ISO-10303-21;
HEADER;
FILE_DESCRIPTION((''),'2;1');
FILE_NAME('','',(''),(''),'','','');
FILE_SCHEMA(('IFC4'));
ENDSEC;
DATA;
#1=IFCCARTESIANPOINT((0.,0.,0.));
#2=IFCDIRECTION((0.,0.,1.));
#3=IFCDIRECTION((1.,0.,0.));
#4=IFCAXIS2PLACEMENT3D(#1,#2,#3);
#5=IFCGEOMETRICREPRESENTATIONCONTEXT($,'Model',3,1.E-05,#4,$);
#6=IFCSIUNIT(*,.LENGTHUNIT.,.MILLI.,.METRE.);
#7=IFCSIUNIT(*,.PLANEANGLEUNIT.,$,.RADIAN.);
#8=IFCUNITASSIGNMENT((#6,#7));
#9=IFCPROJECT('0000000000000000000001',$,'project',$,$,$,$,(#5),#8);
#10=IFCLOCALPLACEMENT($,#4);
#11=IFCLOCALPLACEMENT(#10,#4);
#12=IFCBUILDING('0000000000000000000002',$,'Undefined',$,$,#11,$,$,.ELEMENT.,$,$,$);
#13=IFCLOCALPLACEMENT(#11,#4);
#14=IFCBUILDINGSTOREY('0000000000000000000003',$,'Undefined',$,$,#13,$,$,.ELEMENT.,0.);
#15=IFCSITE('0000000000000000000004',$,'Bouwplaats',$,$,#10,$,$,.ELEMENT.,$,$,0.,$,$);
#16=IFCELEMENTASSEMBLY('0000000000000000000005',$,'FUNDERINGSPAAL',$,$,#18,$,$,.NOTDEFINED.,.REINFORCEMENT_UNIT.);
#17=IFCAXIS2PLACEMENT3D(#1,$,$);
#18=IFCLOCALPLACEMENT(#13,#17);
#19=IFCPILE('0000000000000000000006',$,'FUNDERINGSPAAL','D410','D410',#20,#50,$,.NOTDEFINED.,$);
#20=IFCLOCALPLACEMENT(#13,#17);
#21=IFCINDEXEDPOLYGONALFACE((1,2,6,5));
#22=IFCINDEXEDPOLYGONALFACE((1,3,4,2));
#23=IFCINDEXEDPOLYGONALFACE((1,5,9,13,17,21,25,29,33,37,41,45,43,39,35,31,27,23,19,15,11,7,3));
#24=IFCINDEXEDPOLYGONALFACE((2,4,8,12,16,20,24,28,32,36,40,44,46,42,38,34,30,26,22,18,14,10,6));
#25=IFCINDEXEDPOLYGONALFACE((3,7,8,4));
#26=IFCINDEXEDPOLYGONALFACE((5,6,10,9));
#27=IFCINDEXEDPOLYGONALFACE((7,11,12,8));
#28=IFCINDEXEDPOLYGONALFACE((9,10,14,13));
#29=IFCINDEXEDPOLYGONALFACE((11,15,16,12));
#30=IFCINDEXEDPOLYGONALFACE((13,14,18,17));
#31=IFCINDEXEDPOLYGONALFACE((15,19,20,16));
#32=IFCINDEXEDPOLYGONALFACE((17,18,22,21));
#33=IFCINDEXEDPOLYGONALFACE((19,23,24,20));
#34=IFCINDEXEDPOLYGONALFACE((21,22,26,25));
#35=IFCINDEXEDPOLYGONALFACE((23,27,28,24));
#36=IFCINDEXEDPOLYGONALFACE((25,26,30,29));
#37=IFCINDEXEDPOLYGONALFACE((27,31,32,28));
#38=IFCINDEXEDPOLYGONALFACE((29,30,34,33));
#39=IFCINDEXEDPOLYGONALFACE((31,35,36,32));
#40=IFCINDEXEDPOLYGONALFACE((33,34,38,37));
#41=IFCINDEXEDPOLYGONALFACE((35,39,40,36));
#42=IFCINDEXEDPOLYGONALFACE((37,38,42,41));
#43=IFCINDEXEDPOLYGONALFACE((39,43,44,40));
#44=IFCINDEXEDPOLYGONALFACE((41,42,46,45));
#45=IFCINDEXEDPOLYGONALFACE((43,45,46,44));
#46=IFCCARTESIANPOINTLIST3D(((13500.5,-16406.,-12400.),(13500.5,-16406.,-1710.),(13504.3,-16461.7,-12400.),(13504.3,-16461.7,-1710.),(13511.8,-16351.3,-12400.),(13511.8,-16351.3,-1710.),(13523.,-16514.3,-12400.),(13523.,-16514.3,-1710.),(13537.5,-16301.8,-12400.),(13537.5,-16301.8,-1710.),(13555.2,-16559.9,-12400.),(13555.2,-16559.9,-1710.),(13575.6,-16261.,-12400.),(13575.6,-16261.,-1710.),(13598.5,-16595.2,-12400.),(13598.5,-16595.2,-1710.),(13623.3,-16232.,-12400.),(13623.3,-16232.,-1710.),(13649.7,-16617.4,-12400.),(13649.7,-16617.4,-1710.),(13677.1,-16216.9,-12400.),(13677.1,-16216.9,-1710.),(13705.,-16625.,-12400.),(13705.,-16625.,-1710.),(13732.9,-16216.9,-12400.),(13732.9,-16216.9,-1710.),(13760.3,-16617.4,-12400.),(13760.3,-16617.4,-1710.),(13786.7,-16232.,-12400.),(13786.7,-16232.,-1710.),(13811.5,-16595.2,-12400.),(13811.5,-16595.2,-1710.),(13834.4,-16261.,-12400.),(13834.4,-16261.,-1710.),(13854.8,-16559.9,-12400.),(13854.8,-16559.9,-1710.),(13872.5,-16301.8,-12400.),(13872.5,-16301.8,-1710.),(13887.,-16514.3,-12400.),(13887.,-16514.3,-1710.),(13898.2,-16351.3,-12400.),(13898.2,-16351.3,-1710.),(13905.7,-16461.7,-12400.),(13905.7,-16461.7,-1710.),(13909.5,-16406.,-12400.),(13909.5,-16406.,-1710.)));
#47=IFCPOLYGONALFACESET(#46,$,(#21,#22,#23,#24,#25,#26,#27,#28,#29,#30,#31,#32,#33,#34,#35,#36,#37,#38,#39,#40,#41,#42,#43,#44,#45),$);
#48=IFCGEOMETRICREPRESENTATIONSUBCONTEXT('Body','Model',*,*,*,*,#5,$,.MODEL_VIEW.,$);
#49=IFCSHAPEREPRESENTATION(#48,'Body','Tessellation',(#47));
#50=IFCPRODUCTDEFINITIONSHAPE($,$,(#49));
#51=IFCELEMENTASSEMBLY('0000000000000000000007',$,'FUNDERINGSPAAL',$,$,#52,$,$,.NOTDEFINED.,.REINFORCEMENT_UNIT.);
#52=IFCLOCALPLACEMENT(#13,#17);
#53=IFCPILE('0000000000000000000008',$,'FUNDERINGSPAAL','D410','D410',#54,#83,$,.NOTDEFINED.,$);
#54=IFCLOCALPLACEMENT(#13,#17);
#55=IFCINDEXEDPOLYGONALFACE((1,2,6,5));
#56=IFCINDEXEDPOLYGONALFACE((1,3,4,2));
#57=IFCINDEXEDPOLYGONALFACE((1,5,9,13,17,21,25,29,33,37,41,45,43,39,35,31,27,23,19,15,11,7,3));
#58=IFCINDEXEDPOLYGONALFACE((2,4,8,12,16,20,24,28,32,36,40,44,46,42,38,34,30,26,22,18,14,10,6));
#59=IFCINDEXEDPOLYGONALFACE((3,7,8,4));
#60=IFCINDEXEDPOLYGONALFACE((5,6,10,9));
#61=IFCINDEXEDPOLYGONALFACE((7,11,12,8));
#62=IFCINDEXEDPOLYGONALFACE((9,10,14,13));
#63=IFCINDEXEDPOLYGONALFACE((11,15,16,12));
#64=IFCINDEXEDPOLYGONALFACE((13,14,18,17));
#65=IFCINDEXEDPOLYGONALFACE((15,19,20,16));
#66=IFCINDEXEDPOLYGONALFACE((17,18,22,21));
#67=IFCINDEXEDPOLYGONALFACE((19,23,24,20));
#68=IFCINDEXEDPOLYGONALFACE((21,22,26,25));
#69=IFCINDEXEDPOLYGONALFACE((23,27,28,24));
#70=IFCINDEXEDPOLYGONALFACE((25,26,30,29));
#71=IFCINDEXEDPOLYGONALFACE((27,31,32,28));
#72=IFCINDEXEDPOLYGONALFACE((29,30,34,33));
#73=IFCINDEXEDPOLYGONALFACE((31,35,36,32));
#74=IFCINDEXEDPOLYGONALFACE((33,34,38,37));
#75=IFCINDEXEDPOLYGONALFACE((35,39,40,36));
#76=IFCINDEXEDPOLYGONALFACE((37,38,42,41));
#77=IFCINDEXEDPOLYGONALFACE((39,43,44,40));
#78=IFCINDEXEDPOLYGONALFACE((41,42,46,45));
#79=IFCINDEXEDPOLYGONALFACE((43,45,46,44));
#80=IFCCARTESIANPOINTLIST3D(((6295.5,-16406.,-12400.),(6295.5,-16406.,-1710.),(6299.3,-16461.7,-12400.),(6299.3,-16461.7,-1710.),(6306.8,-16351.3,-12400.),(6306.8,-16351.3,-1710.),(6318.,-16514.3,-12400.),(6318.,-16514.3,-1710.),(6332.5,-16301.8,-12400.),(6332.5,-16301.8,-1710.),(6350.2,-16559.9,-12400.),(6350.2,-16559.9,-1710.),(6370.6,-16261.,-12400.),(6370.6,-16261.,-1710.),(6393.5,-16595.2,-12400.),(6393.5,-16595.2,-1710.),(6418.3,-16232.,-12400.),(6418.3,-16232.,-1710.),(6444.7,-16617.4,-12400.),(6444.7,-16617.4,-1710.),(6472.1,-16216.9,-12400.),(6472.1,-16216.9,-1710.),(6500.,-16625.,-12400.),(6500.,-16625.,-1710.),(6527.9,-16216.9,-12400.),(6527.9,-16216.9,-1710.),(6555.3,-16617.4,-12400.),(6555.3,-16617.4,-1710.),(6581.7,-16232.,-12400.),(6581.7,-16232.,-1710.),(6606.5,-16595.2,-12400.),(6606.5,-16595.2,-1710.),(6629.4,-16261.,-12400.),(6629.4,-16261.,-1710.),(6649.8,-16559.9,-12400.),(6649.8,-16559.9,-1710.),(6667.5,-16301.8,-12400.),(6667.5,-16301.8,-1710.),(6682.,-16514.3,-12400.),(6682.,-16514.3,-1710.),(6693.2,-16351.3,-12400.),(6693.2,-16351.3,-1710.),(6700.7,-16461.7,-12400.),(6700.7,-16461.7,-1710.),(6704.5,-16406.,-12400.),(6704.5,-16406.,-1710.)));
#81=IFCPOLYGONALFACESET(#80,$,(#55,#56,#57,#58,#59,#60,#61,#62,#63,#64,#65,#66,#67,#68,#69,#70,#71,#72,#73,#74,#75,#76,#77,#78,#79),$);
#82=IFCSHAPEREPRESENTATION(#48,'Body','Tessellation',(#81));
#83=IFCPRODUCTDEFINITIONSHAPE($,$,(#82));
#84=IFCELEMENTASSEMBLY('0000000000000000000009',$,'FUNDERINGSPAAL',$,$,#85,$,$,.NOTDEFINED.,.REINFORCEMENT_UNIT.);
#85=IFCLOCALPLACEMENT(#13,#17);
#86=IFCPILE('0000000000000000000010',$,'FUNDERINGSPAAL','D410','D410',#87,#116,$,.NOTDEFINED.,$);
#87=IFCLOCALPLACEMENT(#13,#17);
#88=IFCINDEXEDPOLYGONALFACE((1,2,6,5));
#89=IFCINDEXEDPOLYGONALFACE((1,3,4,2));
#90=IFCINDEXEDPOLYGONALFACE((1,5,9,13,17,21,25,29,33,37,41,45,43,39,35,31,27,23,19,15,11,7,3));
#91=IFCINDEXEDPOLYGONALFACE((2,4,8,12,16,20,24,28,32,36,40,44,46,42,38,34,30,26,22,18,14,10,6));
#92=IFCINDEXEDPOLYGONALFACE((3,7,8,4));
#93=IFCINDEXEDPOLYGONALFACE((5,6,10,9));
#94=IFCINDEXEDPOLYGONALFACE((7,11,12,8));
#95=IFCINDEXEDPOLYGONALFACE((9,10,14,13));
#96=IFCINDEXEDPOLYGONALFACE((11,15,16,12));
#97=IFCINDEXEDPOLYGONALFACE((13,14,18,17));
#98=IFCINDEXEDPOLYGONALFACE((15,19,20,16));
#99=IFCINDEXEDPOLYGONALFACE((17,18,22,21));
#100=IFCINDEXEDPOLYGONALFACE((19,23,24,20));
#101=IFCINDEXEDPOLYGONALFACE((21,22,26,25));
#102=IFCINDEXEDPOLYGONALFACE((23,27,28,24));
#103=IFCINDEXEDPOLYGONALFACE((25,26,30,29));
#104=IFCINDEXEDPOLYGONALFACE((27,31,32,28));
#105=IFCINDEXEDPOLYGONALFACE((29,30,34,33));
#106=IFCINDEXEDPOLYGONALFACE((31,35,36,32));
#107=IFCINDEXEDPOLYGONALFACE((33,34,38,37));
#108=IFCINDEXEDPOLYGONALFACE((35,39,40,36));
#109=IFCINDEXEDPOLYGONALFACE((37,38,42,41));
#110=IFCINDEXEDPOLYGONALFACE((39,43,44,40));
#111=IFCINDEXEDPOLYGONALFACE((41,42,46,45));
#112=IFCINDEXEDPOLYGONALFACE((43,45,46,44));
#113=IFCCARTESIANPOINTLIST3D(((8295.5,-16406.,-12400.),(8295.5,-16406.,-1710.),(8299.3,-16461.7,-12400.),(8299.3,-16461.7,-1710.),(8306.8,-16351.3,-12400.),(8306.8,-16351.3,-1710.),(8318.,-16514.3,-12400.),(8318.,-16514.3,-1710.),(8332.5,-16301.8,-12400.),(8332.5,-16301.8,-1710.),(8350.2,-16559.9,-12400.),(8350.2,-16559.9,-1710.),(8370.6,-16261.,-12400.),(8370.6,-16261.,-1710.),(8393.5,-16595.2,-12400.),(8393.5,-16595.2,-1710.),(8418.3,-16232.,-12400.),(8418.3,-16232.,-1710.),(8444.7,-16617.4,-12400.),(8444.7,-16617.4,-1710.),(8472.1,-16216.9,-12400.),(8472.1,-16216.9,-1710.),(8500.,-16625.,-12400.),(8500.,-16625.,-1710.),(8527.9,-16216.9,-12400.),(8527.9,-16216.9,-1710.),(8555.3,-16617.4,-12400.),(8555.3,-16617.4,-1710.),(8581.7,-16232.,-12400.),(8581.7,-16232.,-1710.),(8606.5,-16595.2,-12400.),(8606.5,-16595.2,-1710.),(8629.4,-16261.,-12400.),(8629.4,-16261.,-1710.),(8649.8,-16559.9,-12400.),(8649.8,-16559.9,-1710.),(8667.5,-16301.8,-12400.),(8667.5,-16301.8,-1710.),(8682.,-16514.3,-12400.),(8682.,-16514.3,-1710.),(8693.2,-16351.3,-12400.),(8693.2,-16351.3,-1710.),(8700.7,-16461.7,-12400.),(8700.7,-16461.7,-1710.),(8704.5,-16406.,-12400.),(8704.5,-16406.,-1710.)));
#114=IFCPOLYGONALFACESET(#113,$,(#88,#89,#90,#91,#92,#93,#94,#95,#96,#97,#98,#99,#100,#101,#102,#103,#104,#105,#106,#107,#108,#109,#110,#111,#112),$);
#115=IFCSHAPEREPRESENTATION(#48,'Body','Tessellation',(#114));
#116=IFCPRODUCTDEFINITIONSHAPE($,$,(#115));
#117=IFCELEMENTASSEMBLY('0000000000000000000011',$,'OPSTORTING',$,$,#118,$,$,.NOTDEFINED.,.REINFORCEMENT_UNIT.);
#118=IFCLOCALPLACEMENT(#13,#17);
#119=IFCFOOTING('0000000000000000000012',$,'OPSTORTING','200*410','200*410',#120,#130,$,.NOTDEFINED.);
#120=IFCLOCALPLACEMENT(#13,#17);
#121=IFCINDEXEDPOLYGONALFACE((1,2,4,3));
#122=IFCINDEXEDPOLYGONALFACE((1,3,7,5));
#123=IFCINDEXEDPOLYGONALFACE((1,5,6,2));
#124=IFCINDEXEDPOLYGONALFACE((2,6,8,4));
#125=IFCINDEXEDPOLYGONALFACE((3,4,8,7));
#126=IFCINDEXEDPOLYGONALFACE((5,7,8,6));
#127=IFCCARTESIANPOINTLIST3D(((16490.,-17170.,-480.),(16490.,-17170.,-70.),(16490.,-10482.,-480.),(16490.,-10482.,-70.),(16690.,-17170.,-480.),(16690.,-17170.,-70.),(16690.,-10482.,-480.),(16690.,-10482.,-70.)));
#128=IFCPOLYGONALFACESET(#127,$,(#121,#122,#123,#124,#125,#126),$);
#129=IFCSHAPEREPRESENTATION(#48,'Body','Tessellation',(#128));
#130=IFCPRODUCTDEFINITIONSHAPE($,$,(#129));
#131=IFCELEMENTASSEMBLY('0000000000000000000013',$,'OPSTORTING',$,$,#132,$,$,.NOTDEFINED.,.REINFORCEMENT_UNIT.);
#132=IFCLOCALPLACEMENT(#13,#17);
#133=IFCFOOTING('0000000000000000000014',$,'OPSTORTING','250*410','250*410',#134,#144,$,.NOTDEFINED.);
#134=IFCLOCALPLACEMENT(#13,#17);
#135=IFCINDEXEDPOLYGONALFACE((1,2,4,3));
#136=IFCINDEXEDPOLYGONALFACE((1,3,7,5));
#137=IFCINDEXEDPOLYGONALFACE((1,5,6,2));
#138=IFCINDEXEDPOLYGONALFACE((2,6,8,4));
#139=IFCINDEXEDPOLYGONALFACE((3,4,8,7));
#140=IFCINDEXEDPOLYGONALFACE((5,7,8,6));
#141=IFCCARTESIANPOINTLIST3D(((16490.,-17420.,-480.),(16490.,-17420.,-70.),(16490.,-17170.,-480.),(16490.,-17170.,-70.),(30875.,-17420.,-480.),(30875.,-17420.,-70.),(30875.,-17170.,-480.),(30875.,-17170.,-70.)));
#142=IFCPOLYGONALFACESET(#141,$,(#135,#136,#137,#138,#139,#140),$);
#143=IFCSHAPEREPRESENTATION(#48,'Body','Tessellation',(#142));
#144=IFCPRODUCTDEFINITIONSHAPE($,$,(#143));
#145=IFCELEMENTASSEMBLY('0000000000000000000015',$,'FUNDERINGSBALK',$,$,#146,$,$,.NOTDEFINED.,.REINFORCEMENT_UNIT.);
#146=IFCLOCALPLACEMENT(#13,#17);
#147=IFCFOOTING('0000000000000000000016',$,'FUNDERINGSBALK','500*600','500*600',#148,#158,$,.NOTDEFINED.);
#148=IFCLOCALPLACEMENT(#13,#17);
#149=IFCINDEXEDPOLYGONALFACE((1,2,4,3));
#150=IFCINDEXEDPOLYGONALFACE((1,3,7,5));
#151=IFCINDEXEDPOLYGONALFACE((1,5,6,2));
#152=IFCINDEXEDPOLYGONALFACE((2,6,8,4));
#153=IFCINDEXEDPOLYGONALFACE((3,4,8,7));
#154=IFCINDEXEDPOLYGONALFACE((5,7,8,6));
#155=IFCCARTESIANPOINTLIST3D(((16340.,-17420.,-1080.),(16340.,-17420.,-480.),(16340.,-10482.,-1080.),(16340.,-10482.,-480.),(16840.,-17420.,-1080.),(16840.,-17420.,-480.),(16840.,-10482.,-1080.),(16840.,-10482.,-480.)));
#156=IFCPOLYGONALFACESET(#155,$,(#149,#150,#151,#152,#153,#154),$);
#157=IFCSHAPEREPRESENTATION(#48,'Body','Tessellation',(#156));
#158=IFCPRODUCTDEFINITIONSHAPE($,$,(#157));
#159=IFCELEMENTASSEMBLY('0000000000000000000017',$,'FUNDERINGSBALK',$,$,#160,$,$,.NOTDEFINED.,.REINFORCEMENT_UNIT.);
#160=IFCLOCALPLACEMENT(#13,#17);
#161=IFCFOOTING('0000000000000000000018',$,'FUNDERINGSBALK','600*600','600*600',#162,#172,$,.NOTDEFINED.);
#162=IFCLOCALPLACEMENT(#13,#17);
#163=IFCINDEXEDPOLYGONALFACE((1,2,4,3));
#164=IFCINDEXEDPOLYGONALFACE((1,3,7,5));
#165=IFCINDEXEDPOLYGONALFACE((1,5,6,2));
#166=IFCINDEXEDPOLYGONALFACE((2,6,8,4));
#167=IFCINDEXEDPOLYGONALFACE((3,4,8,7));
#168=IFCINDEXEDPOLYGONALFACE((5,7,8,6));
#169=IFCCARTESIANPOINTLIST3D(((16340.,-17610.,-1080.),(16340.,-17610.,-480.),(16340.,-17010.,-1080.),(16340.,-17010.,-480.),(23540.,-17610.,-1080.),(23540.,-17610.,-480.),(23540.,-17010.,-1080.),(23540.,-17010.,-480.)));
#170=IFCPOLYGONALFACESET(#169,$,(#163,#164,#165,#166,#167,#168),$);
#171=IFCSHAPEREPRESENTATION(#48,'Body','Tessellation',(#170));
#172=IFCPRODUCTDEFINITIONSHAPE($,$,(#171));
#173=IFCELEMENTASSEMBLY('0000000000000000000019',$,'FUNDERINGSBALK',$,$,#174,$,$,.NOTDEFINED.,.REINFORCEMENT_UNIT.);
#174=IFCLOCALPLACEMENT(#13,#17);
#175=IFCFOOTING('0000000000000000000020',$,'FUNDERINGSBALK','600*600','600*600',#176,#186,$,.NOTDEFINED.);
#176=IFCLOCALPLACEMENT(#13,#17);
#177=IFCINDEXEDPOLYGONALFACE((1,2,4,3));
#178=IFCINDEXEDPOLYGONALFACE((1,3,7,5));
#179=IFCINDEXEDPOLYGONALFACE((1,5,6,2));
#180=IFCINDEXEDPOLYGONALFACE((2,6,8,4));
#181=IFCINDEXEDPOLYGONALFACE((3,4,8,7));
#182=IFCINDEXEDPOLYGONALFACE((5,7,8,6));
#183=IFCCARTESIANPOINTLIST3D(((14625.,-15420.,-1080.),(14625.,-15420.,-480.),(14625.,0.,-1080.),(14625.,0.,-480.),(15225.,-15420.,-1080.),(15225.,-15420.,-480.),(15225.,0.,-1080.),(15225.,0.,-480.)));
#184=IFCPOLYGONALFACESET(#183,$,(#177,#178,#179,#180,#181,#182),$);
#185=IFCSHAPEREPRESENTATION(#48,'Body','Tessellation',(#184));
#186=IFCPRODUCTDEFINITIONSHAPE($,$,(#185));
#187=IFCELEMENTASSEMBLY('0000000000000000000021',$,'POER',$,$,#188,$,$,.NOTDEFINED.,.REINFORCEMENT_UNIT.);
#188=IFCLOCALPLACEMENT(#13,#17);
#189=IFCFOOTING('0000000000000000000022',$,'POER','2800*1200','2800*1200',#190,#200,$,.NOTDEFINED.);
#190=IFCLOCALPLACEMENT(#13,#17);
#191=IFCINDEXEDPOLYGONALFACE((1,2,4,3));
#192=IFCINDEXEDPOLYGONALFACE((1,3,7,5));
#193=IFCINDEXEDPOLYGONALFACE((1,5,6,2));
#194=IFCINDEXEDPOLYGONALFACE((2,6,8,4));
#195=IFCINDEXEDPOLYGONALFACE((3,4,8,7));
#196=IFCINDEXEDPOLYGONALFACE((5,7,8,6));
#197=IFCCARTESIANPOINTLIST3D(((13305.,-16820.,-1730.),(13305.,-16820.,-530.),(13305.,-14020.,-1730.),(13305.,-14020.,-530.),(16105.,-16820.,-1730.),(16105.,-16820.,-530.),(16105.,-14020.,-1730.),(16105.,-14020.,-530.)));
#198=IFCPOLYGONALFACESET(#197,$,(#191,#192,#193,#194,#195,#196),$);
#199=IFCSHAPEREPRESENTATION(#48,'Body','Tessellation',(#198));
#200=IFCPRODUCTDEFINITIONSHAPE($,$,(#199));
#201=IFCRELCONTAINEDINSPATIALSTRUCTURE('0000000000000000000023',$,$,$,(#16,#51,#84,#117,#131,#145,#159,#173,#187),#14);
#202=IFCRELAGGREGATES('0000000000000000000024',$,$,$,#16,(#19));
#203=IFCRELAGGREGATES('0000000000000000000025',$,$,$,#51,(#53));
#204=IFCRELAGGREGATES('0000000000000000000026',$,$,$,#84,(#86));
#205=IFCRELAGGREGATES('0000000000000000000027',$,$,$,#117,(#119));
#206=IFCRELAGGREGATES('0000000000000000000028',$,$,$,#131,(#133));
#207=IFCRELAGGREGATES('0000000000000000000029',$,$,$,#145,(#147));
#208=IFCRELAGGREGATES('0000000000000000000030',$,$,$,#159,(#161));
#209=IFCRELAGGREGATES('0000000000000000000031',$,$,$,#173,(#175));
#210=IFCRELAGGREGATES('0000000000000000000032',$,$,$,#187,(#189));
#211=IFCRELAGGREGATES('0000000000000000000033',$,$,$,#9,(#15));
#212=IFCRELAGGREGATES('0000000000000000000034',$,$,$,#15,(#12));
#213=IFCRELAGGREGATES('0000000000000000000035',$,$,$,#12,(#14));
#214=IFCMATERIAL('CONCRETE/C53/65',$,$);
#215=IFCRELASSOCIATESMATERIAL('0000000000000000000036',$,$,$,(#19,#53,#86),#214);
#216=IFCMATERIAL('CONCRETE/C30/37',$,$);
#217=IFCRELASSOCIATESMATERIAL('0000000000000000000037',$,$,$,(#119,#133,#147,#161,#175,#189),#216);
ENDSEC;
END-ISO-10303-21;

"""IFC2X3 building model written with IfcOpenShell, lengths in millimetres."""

from ifc_helpers import new_model, si_unit, frame, origin_with_axes, origin_2d_with_axis, place, context, subcontext, project, spatial, rectangle, circle, extrude, clip, halfspace, material, element, aggregate, save


model = new_model("IFC2X3")

# Units and contexts
model_context = context("Model", 3, precision=1e-05, world=origin_with_axes())
body_context = subcontext(model_context, "Body", "Model", "MODEL_VIEW")
ifc_project = project(units=[si_unit("LENGTHUNIT", "METRE", prefix="MILLI"), si_unit("PLANEANGLEUNIT", "RADIAN")], contexts=[model_context])

# Site, building, storey
site_placement = place(None, origin_with_axes())
site = spatial("IfcSite", under=ifc_project, at=site_placement, Name="Bouwplaats", CompositionType="ELEMENT", RefElevation=0.0)
building_placement = place(site_placement, origin_with_axes())
building = spatial("IfcBuilding", under=site, at=building_placement, Name="Undefined", CompositionType="ELEMENT")
storey_placement = place(building_placement, origin_with_axes())
storey = spatial("IfcBuildingStorey", under=building, at=storey_placement, Name="Undefined", CompositionType="ELEMENT", Elevation=0.0)

# Element assemblies, piles
ifc_material_1 = material(Name="CONCRETE/C53/65")
assembly_1_placement = place(storey_placement, origin_with_axes())
assembly_1 = element("IfcElementAssembly", 1, at=assembly_1_placement, inside=storey, Name="FUNDERINGSPAAL", AssemblyPlace="NOTDEFINED", PredefinedType="REINFORCEMENT_UNIT")
pile_1_placement = place(assembly_1_placement, frame((13705.0, -16420.0, -1710.0), z_axis=(1.0, 0.0, 0.0), x_axis=(0.0, 0.0, -1.0)))
pile_1 = element("IfcPile", 2, at=pile_1_placement, material=ifc_material_1, Name="FUNDERINGSPAAL", Description="D410", ObjectType="D410", PredefinedType="NOTDEFINED", context=body_context, shape_type="Clipping", body=[
    clip(extrude(circle(Radius=205.0, at=origin_2d_with_axis()), frame((10690.0, 0.0, 0.0), z_axis=(-1.0, 0.0, 0.0), x_axis=(0.0, -1.0, 0.0)), (0.0, 0.0, 1.0), 10690.0), halfspace(frame((0.0, 205.0, -205.0), z_axis=(-1.0, 0.0, 0.0), x_axis=(0.0, 0.0, 1.0)), False)),
])
aggregate(assembly_1, [pile_1])
assembly_2_placement = place(storey_placement, origin_with_axes())
assembly_2 = element("IfcElementAssembly", 3, at=assembly_2_placement, inside=storey, Name="FUNDERINGSPAAL", AssemblyPlace="NOTDEFINED", PredefinedType="REINFORCEMENT_UNIT")
pile_2_placement = place(assembly_2_placement, frame((6500.0, -16420.0, -1710.0), z_axis=(1.0, 0.0, 0.0), x_axis=(0.0, 0.0, -1.0)))
pile_2 = element("IfcPile", 4, at=pile_2_placement, material=ifc_material_1, Name="FUNDERINGSPAAL", Description="D410", ObjectType="D410", PredefinedType="NOTDEFINED", context=body_context, shape_type="Clipping", body=[
    clip(extrude(circle(Radius=205.0, at=origin_2d_with_axis()), frame((10690.0, 0.0, 0.0), z_axis=(-1.0, 0.0, 0.0), x_axis=(0.0, -1.0, 0.0)), (0.0, 0.0, 1.0), 10690.0), halfspace(frame((0.0, 205.0, -205.0), z_axis=(-1.0, 0.0, 0.0), x_axis=(0.0, 0.0, 1.0)), False)),
])
aggregate(assembly_2, [pile_2])
assembly_3_placement = place(storey_placement, origin_with_axes())
assembly_3 = element("IfcElementAssembly", 5, at=assembly_3_placement, inside=storey, Name="FUNDERINGSPAAL", AssemblyPlace="NOTDEFINED", PredefinedType="REINFORCEMENT_UNIT")
pile_3_placement = place(assembly_3_placement, frame((8500.0, -16420.0, -1710.0), z_axis=(1.0, 0.0, 0.0), x_axis=(0.0, 0.0, -1.0)))
pile_3 = element("IfcPile", 6, at=pile_3_placement, material=ifc_material_1, Name="FUNDERINGSPAAL", Description="D410", ObjectType="D410", PredefinedType="NOTDEFINED", context=body_context, shape_type="Clipping", body=[
    clip(extrude(circle(Radius=205.0, at=origin_2d_with_axis()), frame((10690.0, 0.0, 0.0), z_axis=(-1.0, 0.0, 0.0), x_axis=(0.0, -1.0, 0.0)), (0.0, 0.0, 1.0), 10690.0), halfspace(frame((0.0, 205.0, -205.0), z_axis=(-1.0, 0.0, 0.0), x_axis=(0.0, 0.0, 1.0)), False)),
])
aggregate(assembly_3, [pile_3])

# Element assemblies, footings
assembly_4_placement = place(storey_placement, origin_with_axes())
assembly_4 = element("IfcElementAssembly", 7, at=assembly_4_placement, inside=storey, Name="OPSTORTING", AssemblyPlace="NOTDEFINED", PredefinedType="REINFORCEMENT_UNIT")
ifc_material_2 = material(Name="CONCRETE/C30/37")
footing_1_placement = place(assembly_4_placement, frame((16590.0, -17170.0, -275.0), z_axis=(0.0, 0.0, 1.0), x_axis=(0.0, 1.0, 0.0)))
footing_1 = element("IfcFooting", 8, at=footing_1_placement, material=ifc_material_2, Name="OPSTORTING", Description="200*410", ObjectType="200*410", PredefinedType="NOTDEFINED", context=body_context, shape_type="SweptSolid", body=[
    extrude(rectangle(XDim=200.0, YDim=410.0, at=origin_2d_with_axis()), frame((6688.0, 0.0, 0.0), z_axis=(-1.0, 0.0, 0.0), x_axis=(0.0, -1.0, 0.0)), (0.0, 0.0, 1.0), 6688.0),
])
aggregate(assembly_4, [footing_1])
assembly_5_placement = place(storey_placement, origin_with_axes())
assembly_5 = element("IfcElementAssembly", 9, at=assembly_5_placement, inside=storey, Name="OPSTORTING", AssemblyPlace="NOTDEFINED", PredefinedType="REINFORCEMENT_UNIT")
footing_2_placement = place(assembly_5_placement, frame((16490.0, -17295.0, -275.0), z_axis=(0.0, 0.0, 1.0), x_axis=(1.0, 0.0, 0.0)))
footing_2 = element("IfcFooting", 10, at=footing_2_placement, material=ifc_material_2, Name="OPSTORTING", Description="250*410", ObjectType="250*410", PredefinedType="NOTDEFINED", context=body_context, shape_type="SweptSolid", body=[
    extrude(rectangle(XDim=250.0, YDim=410.0, at=origin_2d_with_axis()), frame((14385.0, 0.0, 0.0), z_axis=(-1.0, 0.0, 0.0), x_axis=(0.0, -1.0, 0.0)), (0.0, 0.0, 1.0), 14385.0),
])
aggregate(assembly_5, [footing_2])
assembly_6_placement = place(storey_placement, origin_with_axes())
assembly_6 = element("IfcElementAssembly", 11, at=assembly_6_placement, inside=storey, Name="FUNDERINGSBALK", AssemblyPlace="NOTDEFINED", PredefinedType="REINFORCEMENT_UNIT")
footing_3_placement = place(assembly_6_placement, frame((16590.0, -17420.0, -780.0), z_axis=(0.0, 0.0, 1.0), x_axis=(0.0, 1.0, 0.0)))
footing_3 = element("IfcFooting", 12, at=footing_3_placement, material=ifc_material_2, Name="FUNDERINGSBALK", Description="500*600", ObjectType="500*600", PredefinedType="NOTDEFINED", context=body_context, shape_type="SweptSolid", body=[
    extrude(rectangle(XDim=500.0, YDim=600.0, at=origin_2d_with_axis()), frame((6938.0, 0.0, 0.0), z_axis=(-1.0, 0.0, 0.0), x_axis=(0.0, -1.0, 0.0)), (0.0, 0.0, 1.0), 6938.0),
])
aggregate(assembly_6, [footing_3])
assembly_7_placement = place(storey_placement, origin_with_axes())
assembly_7 = element("IfcElementAssembly", 13, at=assembly_7_placement, inside=storey, Name="FUNDERINGSBALK", AssemblyPlace="NOTDEFINED", PredefinedType="REINFORCEMENT_UNIT")
footing_4_placement = place(assembly_7_placement, frame((16340.0, -17310.0, -780.0), z_axis=(0.0, 0.0, 1.0), x_axis=(1.0, 0.0, 0.0)))
footing_4 = element("IfcFooting", 14, at=footing_4_placement, material=ifc_material_2, Name="FUNDERINGSBALK", Description="600*600", ObjectType="600*600", PredefinedType="NOTDEFINED", context=body_context, shape_type="SweptSolid", body=[
    extrude(rectangle(XDim=600.0, YDim=600.0, at=origin_2d_with_axis()), frame((7200.0, 0.0, 0.0), z_axis=(-1.0, 0.0, 0.0), x_axis=(0.0, -1.0, 0.0)), (0.0, 0.0, 1.0), 7200.0),
])
aggregate(assembly_7, [footing_4])
assembly_8_placement = place(storey_placement, origin_with_axes())
assembly_8 = element("IfcElementAssembly", 15, at=assembly_8_placement, inside=storey, Name="FUNDERINGSBALK", AssemblyPlace="NOTDEFINED", PredefinedType="REINFORCEMENT_UNIT")
footing_5_placement = place(assembly_8_placement, frame((14925.0, -15420.0, -780.0), z_axis=(0.0, 0.0, 1.0), x_axis=(0.0, 1.0, 0.0)))
footing_5 = element("IfcFooting", 16, at=footing_5_placement, material=ifc_material_2, Name="FUNDERINGSBALK", Description="600*600", ObjectType="600*600", PredefinedType="NOTDEFINED", context=body_context, shape_type="SweptSolid", body=[
    extrude(rectangle(XDim=600.0, YDim=600.0, at=origin_2d_with_axis()), frame((15420.0, 0.0, 0.0), z_axis=(-1.0, 0.0, 0.0), x_axis=(0.0, -1.0, 0.0)), (0.0, 0.0, 1.0), 15420.0),
])
aggregate(assembly_8, [footing_5])
assembly_9_placement = place(storey_placement, origin_with_axes())
assembly_9 = element("IfcElementAssembly", 17, at=assembly_9_placement, inside=storey, Name="POER", AssemblyPlace="NOTDEFINED", PredefinedType="REINFORCEMENT_UNIT")
footing_6_placement = place(assembly_9_placement, frame((13305.0, -15420.0, -1130.0), z_axis=(0.0, 0.0, 1.0), x_axis=(1.0, 0.0, 0.0)))
footing_6 = element("IfcFooting", 18, at=footing_6_placement, material=ifc_material_2, Name="POER", Description="2800*1200", ObjectType="2800*1200", PredefinedType="NOTDEFINED", context=body_context, shape_type="SweptSolid", body=[
    extrude(rectangle(XDim=2800.0, YDim=1200.0, at=origin_2d_with_axis()), frame((2800.0, 0.0, 0.0), z_axis=(-1.0, 0.0, 0.0), x_axis=(0.0, -1.0, 0.0)), (0.0, 0.0, 1.0), 2800.0),
])
aggregate(assembly_9, [footing_6])

save(model, "model.ifc")
